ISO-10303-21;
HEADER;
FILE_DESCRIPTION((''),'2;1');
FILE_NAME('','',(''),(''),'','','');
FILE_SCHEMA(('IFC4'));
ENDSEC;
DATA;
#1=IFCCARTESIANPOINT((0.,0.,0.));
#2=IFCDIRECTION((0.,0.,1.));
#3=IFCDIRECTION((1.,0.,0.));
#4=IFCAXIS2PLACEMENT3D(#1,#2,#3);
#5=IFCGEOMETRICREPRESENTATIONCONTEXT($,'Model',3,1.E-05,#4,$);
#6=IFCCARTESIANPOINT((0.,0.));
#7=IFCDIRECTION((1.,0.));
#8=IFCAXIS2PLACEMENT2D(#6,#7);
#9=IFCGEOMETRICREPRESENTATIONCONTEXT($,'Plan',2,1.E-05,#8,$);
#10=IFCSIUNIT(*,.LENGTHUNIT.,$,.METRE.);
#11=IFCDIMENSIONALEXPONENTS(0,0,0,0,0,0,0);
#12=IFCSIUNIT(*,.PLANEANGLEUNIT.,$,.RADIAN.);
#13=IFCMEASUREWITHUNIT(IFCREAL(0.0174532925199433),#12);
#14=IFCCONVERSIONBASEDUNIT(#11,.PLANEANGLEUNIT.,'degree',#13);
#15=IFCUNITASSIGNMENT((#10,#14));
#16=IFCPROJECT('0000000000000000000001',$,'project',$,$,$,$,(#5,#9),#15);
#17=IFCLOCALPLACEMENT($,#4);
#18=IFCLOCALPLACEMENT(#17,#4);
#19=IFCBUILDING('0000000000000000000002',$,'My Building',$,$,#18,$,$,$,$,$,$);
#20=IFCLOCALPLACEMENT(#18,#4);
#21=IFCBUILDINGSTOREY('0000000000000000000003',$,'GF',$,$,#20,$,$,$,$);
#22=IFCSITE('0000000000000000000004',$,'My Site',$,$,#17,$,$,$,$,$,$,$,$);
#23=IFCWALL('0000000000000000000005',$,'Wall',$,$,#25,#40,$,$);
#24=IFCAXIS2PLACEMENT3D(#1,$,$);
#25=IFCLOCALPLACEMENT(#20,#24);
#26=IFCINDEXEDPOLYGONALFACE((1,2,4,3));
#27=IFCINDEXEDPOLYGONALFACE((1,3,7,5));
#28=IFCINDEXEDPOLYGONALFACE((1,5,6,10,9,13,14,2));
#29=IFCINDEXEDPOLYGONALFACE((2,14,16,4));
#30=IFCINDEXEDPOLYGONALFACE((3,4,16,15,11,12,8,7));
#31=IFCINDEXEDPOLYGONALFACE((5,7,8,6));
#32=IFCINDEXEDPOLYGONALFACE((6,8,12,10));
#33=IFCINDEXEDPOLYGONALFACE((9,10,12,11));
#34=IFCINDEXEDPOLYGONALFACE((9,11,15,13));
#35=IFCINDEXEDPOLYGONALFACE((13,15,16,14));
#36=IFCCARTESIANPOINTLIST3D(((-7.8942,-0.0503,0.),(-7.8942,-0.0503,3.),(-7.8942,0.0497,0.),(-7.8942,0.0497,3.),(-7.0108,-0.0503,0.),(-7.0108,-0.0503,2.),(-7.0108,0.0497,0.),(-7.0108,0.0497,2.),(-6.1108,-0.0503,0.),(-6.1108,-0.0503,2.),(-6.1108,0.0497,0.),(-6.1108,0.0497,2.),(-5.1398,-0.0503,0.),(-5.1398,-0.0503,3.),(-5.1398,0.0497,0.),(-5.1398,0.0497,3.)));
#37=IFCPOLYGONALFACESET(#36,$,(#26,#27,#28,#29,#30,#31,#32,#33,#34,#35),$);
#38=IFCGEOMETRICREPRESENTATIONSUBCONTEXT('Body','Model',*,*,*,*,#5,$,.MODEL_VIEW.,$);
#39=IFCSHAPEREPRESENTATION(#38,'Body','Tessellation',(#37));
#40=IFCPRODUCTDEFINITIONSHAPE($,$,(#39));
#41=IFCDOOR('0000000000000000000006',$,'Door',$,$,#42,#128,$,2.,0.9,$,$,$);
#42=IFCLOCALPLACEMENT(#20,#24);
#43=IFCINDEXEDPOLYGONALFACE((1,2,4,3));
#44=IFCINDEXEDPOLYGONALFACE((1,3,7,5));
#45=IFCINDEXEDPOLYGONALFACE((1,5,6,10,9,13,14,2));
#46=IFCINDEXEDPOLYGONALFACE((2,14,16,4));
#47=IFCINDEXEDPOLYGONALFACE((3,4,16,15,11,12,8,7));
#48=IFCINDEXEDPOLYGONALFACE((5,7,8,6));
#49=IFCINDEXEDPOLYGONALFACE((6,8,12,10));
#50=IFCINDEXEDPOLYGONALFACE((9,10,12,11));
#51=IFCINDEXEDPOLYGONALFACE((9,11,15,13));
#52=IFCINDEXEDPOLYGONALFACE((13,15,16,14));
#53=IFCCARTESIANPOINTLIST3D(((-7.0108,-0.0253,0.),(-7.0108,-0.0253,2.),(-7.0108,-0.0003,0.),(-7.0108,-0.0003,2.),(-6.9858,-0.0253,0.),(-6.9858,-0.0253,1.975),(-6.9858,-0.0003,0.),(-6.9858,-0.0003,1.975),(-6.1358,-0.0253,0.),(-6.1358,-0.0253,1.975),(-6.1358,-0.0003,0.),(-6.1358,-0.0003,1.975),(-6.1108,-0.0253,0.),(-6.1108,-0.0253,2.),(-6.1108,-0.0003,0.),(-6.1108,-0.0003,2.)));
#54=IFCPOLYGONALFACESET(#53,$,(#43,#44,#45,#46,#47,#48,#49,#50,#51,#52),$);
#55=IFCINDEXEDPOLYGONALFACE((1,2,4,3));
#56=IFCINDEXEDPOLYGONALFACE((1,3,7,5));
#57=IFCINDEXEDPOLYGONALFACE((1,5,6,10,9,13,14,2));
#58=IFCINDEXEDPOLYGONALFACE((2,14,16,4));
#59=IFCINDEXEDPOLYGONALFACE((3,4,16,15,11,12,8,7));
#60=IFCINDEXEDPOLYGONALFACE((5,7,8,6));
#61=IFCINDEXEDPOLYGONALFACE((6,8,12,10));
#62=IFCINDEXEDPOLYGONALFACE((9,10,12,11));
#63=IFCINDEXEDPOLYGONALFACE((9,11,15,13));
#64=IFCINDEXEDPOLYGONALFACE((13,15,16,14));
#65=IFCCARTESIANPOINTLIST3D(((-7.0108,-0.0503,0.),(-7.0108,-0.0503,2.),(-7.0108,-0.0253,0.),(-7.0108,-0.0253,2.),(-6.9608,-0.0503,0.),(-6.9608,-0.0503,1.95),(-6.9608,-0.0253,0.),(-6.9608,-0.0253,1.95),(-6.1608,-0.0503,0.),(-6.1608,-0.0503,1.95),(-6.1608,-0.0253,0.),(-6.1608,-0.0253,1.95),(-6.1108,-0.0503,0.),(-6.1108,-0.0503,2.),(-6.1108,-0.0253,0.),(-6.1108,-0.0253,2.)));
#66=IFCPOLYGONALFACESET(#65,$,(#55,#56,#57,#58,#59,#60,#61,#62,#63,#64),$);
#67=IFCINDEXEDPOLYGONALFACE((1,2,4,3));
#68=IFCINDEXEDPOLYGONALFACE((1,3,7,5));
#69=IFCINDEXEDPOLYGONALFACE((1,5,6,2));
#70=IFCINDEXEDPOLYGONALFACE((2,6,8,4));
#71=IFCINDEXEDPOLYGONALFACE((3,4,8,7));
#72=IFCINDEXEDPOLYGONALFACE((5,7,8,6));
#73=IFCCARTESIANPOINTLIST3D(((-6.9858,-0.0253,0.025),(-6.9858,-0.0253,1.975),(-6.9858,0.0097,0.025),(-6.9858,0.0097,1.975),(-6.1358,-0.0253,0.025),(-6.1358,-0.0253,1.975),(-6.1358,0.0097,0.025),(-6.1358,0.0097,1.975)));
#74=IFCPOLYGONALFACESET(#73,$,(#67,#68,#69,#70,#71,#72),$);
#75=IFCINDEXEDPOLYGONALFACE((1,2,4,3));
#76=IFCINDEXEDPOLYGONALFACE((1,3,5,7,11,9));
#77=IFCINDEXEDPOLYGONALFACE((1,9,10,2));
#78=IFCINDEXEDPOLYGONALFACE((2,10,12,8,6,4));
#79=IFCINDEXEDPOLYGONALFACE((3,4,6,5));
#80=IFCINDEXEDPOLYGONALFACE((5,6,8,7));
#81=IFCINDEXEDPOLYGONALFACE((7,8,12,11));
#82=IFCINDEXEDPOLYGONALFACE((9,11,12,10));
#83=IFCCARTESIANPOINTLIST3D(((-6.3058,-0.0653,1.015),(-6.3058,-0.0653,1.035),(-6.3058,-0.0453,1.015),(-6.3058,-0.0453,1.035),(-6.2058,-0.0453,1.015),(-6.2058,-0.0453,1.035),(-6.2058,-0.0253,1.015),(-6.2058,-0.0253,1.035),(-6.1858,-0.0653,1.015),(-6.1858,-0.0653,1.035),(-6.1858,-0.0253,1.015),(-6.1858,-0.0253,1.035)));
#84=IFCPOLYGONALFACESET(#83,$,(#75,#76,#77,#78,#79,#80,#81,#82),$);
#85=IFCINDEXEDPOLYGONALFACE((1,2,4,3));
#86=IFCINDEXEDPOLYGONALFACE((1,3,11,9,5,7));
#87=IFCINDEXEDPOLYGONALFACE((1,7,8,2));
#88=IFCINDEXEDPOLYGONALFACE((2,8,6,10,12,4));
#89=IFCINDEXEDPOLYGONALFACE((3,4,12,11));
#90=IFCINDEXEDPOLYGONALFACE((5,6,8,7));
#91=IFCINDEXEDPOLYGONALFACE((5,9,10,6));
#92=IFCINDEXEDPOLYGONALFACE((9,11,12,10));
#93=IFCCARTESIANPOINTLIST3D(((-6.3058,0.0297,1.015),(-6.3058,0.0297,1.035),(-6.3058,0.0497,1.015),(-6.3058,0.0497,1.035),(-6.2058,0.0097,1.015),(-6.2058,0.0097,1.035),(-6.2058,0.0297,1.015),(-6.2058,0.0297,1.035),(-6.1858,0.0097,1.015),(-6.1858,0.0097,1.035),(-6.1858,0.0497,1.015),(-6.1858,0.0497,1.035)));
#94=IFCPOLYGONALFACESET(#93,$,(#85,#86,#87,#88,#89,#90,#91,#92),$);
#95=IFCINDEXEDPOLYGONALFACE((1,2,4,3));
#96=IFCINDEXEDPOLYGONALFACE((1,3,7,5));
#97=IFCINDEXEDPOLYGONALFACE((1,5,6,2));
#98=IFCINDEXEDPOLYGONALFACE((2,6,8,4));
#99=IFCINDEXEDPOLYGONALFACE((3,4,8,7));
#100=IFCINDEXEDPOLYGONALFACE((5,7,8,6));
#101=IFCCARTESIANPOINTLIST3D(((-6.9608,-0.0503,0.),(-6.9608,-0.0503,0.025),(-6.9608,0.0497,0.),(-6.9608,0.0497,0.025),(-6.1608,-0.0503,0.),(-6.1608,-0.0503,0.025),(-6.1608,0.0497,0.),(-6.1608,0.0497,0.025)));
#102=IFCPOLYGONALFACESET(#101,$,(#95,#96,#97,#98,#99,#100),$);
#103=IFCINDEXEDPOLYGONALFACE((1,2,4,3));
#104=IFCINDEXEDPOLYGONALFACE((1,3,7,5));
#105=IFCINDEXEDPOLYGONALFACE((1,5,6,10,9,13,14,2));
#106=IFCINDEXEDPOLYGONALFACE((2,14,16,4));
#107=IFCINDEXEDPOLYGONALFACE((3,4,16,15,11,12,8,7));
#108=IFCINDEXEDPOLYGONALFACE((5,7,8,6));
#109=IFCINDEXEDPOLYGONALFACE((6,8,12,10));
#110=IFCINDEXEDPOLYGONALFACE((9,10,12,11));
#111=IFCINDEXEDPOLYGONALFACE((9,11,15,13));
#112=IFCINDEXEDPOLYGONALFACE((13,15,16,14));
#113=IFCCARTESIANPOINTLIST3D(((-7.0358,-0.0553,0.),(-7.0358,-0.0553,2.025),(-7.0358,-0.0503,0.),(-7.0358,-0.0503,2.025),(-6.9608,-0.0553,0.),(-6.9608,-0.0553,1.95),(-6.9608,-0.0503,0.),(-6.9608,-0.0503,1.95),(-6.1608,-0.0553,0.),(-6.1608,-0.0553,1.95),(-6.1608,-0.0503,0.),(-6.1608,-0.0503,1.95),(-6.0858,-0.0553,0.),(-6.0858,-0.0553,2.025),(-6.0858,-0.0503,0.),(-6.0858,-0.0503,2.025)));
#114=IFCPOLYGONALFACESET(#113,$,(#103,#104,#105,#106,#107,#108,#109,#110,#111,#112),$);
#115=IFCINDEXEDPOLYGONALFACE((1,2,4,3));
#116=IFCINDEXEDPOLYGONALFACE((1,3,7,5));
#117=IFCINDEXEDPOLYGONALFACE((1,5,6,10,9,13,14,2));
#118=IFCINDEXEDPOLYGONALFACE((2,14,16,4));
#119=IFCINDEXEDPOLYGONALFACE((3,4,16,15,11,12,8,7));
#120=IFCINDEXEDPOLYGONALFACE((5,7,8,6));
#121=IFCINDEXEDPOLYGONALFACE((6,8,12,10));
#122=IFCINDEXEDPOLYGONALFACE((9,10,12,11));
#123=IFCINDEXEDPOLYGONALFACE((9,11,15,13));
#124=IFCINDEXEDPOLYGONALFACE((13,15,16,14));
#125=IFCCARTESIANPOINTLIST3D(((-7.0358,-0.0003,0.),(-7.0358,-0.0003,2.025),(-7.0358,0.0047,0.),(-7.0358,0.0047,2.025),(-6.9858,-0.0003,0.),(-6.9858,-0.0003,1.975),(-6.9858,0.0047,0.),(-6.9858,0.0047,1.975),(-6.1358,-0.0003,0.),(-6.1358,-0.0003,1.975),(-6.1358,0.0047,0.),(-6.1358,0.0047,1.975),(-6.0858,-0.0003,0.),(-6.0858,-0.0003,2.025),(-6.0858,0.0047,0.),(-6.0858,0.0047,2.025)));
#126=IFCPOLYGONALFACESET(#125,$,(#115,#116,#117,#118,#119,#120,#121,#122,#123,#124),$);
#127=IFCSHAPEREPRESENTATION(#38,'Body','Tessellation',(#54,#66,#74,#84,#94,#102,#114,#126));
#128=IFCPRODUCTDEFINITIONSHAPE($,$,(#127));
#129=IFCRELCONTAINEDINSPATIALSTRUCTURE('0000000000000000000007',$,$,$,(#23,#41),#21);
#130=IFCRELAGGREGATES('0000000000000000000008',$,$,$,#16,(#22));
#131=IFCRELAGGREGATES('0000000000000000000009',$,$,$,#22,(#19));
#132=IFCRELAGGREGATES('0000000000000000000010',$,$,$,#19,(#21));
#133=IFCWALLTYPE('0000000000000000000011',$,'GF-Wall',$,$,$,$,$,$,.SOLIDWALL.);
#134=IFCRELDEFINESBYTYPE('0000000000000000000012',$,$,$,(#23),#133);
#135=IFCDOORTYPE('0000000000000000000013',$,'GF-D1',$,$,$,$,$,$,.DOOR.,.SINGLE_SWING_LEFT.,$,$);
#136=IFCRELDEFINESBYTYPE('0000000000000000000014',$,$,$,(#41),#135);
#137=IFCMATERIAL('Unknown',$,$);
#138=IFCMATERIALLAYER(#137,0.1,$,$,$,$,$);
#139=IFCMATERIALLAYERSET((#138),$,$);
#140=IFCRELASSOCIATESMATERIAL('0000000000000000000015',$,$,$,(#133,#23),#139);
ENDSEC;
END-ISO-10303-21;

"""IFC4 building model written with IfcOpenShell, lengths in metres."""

from ifc_helpers import new_model, entity, si_unit, converted_unit, frame, origin_with_axes, origin_2d_with_axis, place, context, subcontext, project, spatial, line, indexed_curve, outline, extrude, shape, source, transform, mapped, material, layer, layer_set, layer_usage, type_object, type_shapes, element, fill, save


model = new_model("IFC4")

# Units and contexts
model_context = context("Model", 3, precision=1e-05, world=origin_with_axes())
plan_context = context("Plan", 2, precision=1e-05, world=origin_2d_with_axis())
body_context_1 = subcontext(model_context, "Body", "Model", "MODEL_VIEW")
body_context_2 = subcontext(plan_context, "Body", "Plan", "PLAN_VIEW")
ifc_project = project(units=[si_unit("LENGTHUNIT", "METRE"), converted_unit("PLANEANGLEUNIT", "degree", entity("IfcReal", 0.0174532925199433), si_unit("PLANEANGLEUNIT", "RADIAN"), dimensions=[0, 0, 0, 0, 0, 0, 0])], contexts=[model_context, plan_context])

# Site, building, storey
site_placement = place(None, origin_with_axes())
site = spatial("IfcSite", under=ifc_project, at=site_placement, Name="My Site")
building_placement = place(site_placement, origin_with_axes())
building = spatial("IfcBuilding", under=site, at=building_placement, Name="My Building")
storey_placement = place(building_placement, origin_with_axes())
storey = spatial("IfcBuildingStorey", under=building, at=storey_placement, Name="GF")

# Shared definitions
ifc_material = material(Name="Unknown")

# Shared definitions
ifc_layer_1 = layer(ifc_material, 0.1)
ifc_layer_set_1 = layer_set([ifc_layer_1])
wall_type = type_object("IfcWallType", Name="GF-Wall", PredefinedType="SOLIDWALL", material=ifc_layer_set_1)

# Shared definitions
shared_shape_1 = source(origin_with_axes(), body_context_1, "Body", "SweptSolid", [
    extrude(outline(indexed_curve([(0.0, 0.0), (0.9, 0.0), (0.9, 2.0), (0.0, 2.0)], segments=[line(1, 2, 3, 4, 1)])), frame((0.0, -0.6, 0.0), z_axis=(0.0, -1.0, 0.0), x_axis=(1.0, 0.0, 0.0)), (0.0, 0.0, -1.0), 1.2),
])
door_type = type_object("IfcDoorType", Name="GF-D1", OperationType="SINGLE_SWING_LEFT", PredefinedType="DOOR")
shared_shape_2 = source(origin_with_axes(), body_context_1, "Body", "SweptSolid", [
    extrude(outline(indexed_curve([(0.0, 0.0), (0.0, 2.0), (0.9, 2.0), (0.9, 0.0), (0.875, 0.0), (0.875, 1.975), (0.025, 1.975), (0.025, 0.0)], segments=[line(1, 2, 3, 4, 5, 6, 7, 8, 1)])), frame((0.0, 0.025, 0.0), z_axis=(0.0, -1.0, 0.0), x_axis=(1.0, 0.0, 0.0)), (0.0, 0.0, -1.0), 0.025),
    extrude(outline(indexed_curve([(0.0, 0.0), (0.0, 2.0), (0.9, 2.0), (0.9, 0.0), (0.85, 0.0), (0.85, 1.95), (0.05, 1.95), (0.05, 0.0)], segments=[line(1, 2, 3, 4, 5, 6, 7, 8, 1)])), frame((0.0, 0.0, 0.0), z_axis=(0.0, -1.0, 0.0), x_axis=(1.0, 0.0, 0.0)), (0.0, 0.0, -1.0), 0.025),
    extrude(outline(indexed_curve([(0.0, 0.0), (0.85, 0.0), (0.85, 0.035), (0.0, 0.035)], segments=[line(1, 2, 3, 4, 1)])), frame((0.025, 0.025, 0.025), z_axis=(0.0, 0.0, 1.0), x_axis=(1.0, 0.0, 0.0)), (0.0, 0.0, 1.0), 1.95),
    extrude(outline(indexed_curve([(0.0, 0.0), (0.0, -0.04), (-0.12, -0.04), (-0.12, -0.02), (-0.02, -0.02), (-0.02, 0.0)], segments=[line(1, 2, 3, 4, 5, 6, 1)])), frame((0.825, 0.025, 1.015), z_axis=(0.0, 0.0, 1.0), x_axis=(1.0, 0.0, 0.0)), (0.0, 0.0, 1.0), 0.02),
    extrude(outline(indexed_curve([(0.0, 0.0), (0.0, 0.04), (-0.12, 0.04), (-0.12, 0.02), (-0.02, 0.02), (-0.02, 0.0)], segments=[line(1, 2, 3, 4, 5, 6, 1)])), frame((0.825, 0.06, 1.015), z_axis=(0.0, 0.0, 1.0), x_axis=(1.0, 0.0, 0.0)), (0.0, 0.0, 1.0), 0.02),
    extrude(outline(indexed_curve([(0.0, 0.0), (0.8, 0.0), (0.8, 0.1), (0.0, 0.1)], segments=[line(1, 2, 3, 4, 1)])), frame((0.05, 0.0, 0.0), z_axis=(0.0, 0.0, 1.0), x_axis=(1.0, 0.0, 0.0)), (0.0, 0.0, 1.0), 0.025),
    extrude(outline(indexed_curve([(0.0, 0.0), (0.0, 2.025), (0.95, 2.025), (0.95, 0.0), (0.875, 0.0), (0.875, 1.95), (0.075, 1.95), (0.075, 0.0)], segments=[line(1, 2, 3, 4, 5, 6, 7, 8, 1)])), frame((-0.025, -0.005, 0.0), z_axis=(0.0, -1.0, 0.0), x_axis=(1.0, 0.0, 0.0)), (0.0, 0.0, -1.0), 0.005),
    extrude(outline(indexed_curve([(0.0, 0.0), (0.0, 2.025), (0.95, 2.025), (0.95, 0.0), (0.9, 0.0), (0.9, 1.975), (0.05, 1.975), (0.05, 0.0)], segments=[line(1, 2, 3, 4, 5, 6, 7, 8, 1)])), frame((-0.025, 0.05, 0.0), z_axis=(0.0, -1.0, 0.0), x_axis=(1.0, 0.0, 0.0)), (0.0, 0.0, -1.0), 0.005),
])
shared_shape_3 = source(origin_with_axes(), body_context_2, "Body", "Curve2D", [
    entity("IfcIndexedPolyCurve", entity("IfcCartesianPointList2D", [[0.0, 0.0], [0.0, 0.05], [0.025, 0.05], [0.025, 0.025], [0.05, 0.025], [0.05, 0.0]]), [entity("IfcLineIndex", [1, 2, 3, 4, 5, 6, 1])]),
    entity("IfcIndexedPolyCurve", entity("IfcCartesianPointList2D", [[0.9, 0.0], [0.9, 0.05], [0.875, 0.05], [0.875, 0.025], [0.85, 0.025], [0.85, 0.0]]), [entity("IfcLineIndex", [1, 2, 3, 4, 5, 6, 1])]),
    entity("IfcTrimmedCurve", entity("IfcEllipse", entity("IfcAxis2Placement2D", entity("IfcCartesianPoint", [0.06, 0.05]), entity("IfcDirection", [1.0, 0.0])), 0.815, 0.85), [entity("IfcCartesianPoint", [0.875, 0.05])], [entity("IfcCartesianPoint", [0.06, 0.9])], True, "CARTESIAN"),
    entity("IfcIndexedPolyCurve", entity("IfcCartesianPointList2D", [[0.025, 0.05], [0.06, 0.05], [0.06, 0.9], [0.025, 0.9]]), [entity("IfcLineIndex", [1, 2, 3, 4, 1])]),
])
type_shapes(door_type, [shared_shape_2, shared_shape_3])

# Wall, opening, door
ifc_layer_usage_1 = layer_usage(ifc_layer_set_1, "AXIS2", "POSITIVE", 0.0)
wall_1_placement = place(storey_placement, frame((-7.8942, -0.0503, 0.0), z_axis=(0.0, 0.0, 1.0), x_axis=(1.0, 0.0, 0.0)))
wall_1 = element("IfcWall", 1, at=wall_1_placement, inside=storey, type_object=wall_type, material=ifc_layer_usage_1, Name="Wall", context=body_context_1, shape_type="SweptSolid", body=[
    extrude(outline(indexed_curve([(0.0, 0.0), (0.0, 0.1), (2.7545, 0.1), (2.7545, 0.0)], segments=[line(1, 2, 3, 4, 1)])), origin_with_axes(), (0.0, 0.0, 1.0), 3.0),
])
opening_1_placement = place(wall_1_placement, frame((0.8835, 0.0, 0.0), z_axis=(0.0, 0.0, 1.0), x_axis=(1.0, 0.0, 0.0)))
opening_1 = element("IfcOpeningElement", 2, at=opening_1_placement, cuts=wall_1, PredefinedType="OPENING", context=body_context_1, shape_type="MappedRepresentation", body=[
    mapped(shared_shape_1, transform((0.0, 0.0, 0.0), x_axis=(1.0, 0.0, 0.0), y_axis=(0.0, 1.0, 0.0), z_axis=(0.0, 0.0, 1.0), scale=1.0)),
])
door_1_placement = place(opening_1_placement, origin_with_axes())
door_1 = element("IfcDoor", 3, at=door_1_placement, inside=storey, type_object=door_type, Name="Door", OverallHeight=2.0, OverallWidth=0.9, shapes=[
    shape(body_context_1, "Body", "MappedRepresentation", [mapped(shared_shape_2, transform((0.0, 0.0, 0.0), x_axis=(1.0, 0.0, 0.0), y_axis=(0.0, 1.0, 0.0), z_axis=(0.0, 0.0, 1.0), scale=1.0))]),
    shape(body_context_2, "Body", "MappedRepresentation", [mapped(shared_shape_3, transform((0.0, 0.0, 0.0), x_axis=(1.0, 0.0, 0.0), y_axis=(0.0, 1.0, 0.0), z_axis=(0.0, 0.0, 1.0), scale=1.0))]),
])
fill(opening_1, door_1)

save(model, "model.ifc")
